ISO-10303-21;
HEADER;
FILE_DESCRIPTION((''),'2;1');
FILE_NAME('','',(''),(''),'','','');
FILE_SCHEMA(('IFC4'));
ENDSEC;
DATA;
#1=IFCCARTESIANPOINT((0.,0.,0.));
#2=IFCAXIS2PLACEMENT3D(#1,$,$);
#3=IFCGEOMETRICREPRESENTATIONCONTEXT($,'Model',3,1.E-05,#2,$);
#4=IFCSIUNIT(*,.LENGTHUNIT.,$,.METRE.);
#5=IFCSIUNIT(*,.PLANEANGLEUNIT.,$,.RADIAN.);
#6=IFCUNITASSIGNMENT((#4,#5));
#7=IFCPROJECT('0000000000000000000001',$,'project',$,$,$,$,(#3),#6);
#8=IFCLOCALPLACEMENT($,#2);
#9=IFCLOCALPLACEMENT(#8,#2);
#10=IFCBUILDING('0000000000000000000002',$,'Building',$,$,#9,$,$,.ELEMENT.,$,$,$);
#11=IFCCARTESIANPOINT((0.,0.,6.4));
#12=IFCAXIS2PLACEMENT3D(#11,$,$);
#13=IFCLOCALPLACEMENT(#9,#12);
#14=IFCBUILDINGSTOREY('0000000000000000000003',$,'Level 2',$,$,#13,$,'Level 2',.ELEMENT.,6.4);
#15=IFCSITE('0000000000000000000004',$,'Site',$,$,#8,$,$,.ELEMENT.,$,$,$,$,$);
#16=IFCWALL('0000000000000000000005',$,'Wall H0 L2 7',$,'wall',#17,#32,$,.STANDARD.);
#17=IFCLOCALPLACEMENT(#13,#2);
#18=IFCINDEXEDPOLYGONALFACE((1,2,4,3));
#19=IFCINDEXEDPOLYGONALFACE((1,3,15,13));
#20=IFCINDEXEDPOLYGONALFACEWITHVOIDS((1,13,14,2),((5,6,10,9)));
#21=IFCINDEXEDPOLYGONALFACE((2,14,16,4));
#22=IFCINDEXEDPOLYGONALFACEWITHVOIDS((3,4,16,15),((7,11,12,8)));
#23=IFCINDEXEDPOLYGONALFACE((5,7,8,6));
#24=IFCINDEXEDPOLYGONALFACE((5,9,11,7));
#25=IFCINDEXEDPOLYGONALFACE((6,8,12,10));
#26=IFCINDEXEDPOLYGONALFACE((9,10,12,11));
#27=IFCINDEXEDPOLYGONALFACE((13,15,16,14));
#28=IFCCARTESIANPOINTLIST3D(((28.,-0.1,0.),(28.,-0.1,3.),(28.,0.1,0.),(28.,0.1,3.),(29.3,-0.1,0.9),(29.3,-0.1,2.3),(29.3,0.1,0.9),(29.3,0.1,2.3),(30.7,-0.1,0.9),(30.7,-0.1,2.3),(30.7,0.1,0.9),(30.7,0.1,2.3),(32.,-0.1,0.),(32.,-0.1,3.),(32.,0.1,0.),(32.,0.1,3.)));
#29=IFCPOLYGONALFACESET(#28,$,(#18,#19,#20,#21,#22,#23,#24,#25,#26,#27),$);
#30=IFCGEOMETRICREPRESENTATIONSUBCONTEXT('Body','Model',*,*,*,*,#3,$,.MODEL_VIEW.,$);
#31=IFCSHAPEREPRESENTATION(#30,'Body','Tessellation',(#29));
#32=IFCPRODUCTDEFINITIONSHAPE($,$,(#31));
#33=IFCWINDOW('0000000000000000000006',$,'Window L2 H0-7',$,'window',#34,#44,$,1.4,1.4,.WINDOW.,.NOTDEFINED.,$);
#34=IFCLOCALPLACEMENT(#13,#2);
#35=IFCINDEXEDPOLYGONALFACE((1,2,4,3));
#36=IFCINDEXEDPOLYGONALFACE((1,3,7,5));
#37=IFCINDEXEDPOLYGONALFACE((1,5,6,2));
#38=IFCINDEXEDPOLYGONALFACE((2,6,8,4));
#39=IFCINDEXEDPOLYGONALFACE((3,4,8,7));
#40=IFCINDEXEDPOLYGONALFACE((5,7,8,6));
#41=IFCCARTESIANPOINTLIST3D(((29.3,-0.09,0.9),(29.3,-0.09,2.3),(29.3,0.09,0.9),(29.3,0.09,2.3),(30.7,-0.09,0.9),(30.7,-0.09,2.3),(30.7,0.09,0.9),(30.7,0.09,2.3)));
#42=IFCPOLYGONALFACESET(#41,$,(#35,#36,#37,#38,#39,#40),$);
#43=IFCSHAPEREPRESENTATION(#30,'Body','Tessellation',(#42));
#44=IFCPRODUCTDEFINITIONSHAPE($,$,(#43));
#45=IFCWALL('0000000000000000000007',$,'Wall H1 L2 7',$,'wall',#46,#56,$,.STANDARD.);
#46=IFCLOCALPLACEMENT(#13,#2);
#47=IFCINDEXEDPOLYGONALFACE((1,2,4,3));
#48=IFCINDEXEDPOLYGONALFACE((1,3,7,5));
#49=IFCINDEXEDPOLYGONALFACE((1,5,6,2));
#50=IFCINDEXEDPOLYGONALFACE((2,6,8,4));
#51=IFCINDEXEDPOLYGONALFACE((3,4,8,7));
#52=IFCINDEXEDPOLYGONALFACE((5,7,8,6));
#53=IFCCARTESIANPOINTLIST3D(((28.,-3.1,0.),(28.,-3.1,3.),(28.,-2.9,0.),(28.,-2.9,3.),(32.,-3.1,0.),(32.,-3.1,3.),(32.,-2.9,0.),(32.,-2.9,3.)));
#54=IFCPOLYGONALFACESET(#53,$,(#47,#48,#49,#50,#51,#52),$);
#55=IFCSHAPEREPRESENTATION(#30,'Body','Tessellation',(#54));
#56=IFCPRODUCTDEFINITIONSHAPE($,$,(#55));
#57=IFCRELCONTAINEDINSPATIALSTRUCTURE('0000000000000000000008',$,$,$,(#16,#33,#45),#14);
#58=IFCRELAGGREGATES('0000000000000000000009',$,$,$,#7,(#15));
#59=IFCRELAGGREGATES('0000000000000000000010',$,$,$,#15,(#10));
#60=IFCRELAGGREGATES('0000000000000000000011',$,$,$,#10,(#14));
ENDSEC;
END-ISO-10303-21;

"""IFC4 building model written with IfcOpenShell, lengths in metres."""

from ifc_helpers import new_model, si_unit, frame, frame_2d, origin, origin_2d, place, context, subcontext, project, spatial, rectangle, extrude, element, fill, save


model = new_model("IFC4")

# Units and contexts
model_context = context("Model", 3, precision=1e-05, world=origin())
body_context = subcontext(model_context, "Body", "Model", "MODEL_VIEW")
ifc_project = project(units=[si_unit("LENGTHUNIT", "METRE"), si_unit("PLANEANGLEUNIT", "RADIAN")], contexts=[model_context])

# Site, building, storey
site_placement = place(None, origin())
site = spatial("IfcSite", under=ifc_project, at=site_placement, Name="Site", CompositionType="ELEMENT")
building_placement = place(site_placement, origin())
building = spatial("IfcBuilding", under=site, at=building_placement, Name="Building", CompositionType="ELEMENT")
storey_placement = place(building_placement, frame((0.0, 0.0, 6.4)))
storey = spatial("IfcBuildingStorey", under=building, at=storey_placement, Name="Level 2", LongName="Level 2", CompositionType="ELEMENT", Elevation=6.4)

# Wall, opening, window
wall_1_placement = place(storey_placement, frame((28.0, 0.0, 0.0), z_axis=(0.0, 0.0, 1.0), x_axis=(1.0, 0.0, 0.0)))
wall_1 = element("IfcWall", 1, at=wall_1_placement, inside=storey, Name="Wall H0 L2 7", ObjectType="wall", PredefinedType="STANDARD", context=body_context, shape_type="SweptSolid", body=[
    extrude(rectangle(XDim=4.0, YDim=0.2, at=frame_2d((2.0, 0.0))), origin(), (0.0, 0.0, 1.0), 3.0),
])
opening_1_placement = place(storey_placement, frame((30.0, 0.0, 0.9), z_axis=(0.0, 0.0, 1.0), x_axis=(1.0, 0.0, 0.0)))
opening_1 = element("IfcOpeningElement", 2, at=opening_1_placement, cuts=wall_1, ObjectType="Opening", PredefinedType="OPENING", context=body_context, shape_type="SweptSolid", body=[
    extrude(rectangle(XDim=1.4, YDim=0.22, at=origin_2d()), origin(), (0.0, 0.0, 1.0), 1.4),
])
window_1_placement = place(storey_placement, frame((30.0, 0.0, 0.9), z_axis=(0.0, 0.0, 1.0), x_axis=(1.0, 0.0, 0.0)))
window_1 = element("IfcWindow", 3, at=window_1_placement, inside=storey, Name="Window L2 H0-7", ObjectType="window", OverallHeight=1.4, OverallWidth=1.4, PartitioningType="NOTDEFINED", PredefinedType="WINDOW", context=body_context, shape_type="SweptSolid", body=[
    extrude(rectangle(XDim=1.4, YDim=0.18, at=origin_2d()), origin(), (0.0, 0.0, 1.0), 1.4),
])
fill(opening_1, window_1)

# Wall
wall_2_placement = place(storey_placement, frame((28.0, -3.0, 0.0), z_axis=(0.0, 0.0, 1.0), x_axis=(1.0, 0.0, 0.0)))
element("IfcWall", 4, at=wall_2_placement, inside=storey, Name="Wall H1 L2 7", ObjectType="wall", PredefinedType="STANDARD", context=body_context, shape_type="SweptSolid", body=[
    extrude(rectangle(XDim=4.0, YDim=0.2, at=frame_2d((2.0, 0.0))), origin(), (0.0, 0.0, 1.0), 3.0),
])

save(model, "model.ifc")
